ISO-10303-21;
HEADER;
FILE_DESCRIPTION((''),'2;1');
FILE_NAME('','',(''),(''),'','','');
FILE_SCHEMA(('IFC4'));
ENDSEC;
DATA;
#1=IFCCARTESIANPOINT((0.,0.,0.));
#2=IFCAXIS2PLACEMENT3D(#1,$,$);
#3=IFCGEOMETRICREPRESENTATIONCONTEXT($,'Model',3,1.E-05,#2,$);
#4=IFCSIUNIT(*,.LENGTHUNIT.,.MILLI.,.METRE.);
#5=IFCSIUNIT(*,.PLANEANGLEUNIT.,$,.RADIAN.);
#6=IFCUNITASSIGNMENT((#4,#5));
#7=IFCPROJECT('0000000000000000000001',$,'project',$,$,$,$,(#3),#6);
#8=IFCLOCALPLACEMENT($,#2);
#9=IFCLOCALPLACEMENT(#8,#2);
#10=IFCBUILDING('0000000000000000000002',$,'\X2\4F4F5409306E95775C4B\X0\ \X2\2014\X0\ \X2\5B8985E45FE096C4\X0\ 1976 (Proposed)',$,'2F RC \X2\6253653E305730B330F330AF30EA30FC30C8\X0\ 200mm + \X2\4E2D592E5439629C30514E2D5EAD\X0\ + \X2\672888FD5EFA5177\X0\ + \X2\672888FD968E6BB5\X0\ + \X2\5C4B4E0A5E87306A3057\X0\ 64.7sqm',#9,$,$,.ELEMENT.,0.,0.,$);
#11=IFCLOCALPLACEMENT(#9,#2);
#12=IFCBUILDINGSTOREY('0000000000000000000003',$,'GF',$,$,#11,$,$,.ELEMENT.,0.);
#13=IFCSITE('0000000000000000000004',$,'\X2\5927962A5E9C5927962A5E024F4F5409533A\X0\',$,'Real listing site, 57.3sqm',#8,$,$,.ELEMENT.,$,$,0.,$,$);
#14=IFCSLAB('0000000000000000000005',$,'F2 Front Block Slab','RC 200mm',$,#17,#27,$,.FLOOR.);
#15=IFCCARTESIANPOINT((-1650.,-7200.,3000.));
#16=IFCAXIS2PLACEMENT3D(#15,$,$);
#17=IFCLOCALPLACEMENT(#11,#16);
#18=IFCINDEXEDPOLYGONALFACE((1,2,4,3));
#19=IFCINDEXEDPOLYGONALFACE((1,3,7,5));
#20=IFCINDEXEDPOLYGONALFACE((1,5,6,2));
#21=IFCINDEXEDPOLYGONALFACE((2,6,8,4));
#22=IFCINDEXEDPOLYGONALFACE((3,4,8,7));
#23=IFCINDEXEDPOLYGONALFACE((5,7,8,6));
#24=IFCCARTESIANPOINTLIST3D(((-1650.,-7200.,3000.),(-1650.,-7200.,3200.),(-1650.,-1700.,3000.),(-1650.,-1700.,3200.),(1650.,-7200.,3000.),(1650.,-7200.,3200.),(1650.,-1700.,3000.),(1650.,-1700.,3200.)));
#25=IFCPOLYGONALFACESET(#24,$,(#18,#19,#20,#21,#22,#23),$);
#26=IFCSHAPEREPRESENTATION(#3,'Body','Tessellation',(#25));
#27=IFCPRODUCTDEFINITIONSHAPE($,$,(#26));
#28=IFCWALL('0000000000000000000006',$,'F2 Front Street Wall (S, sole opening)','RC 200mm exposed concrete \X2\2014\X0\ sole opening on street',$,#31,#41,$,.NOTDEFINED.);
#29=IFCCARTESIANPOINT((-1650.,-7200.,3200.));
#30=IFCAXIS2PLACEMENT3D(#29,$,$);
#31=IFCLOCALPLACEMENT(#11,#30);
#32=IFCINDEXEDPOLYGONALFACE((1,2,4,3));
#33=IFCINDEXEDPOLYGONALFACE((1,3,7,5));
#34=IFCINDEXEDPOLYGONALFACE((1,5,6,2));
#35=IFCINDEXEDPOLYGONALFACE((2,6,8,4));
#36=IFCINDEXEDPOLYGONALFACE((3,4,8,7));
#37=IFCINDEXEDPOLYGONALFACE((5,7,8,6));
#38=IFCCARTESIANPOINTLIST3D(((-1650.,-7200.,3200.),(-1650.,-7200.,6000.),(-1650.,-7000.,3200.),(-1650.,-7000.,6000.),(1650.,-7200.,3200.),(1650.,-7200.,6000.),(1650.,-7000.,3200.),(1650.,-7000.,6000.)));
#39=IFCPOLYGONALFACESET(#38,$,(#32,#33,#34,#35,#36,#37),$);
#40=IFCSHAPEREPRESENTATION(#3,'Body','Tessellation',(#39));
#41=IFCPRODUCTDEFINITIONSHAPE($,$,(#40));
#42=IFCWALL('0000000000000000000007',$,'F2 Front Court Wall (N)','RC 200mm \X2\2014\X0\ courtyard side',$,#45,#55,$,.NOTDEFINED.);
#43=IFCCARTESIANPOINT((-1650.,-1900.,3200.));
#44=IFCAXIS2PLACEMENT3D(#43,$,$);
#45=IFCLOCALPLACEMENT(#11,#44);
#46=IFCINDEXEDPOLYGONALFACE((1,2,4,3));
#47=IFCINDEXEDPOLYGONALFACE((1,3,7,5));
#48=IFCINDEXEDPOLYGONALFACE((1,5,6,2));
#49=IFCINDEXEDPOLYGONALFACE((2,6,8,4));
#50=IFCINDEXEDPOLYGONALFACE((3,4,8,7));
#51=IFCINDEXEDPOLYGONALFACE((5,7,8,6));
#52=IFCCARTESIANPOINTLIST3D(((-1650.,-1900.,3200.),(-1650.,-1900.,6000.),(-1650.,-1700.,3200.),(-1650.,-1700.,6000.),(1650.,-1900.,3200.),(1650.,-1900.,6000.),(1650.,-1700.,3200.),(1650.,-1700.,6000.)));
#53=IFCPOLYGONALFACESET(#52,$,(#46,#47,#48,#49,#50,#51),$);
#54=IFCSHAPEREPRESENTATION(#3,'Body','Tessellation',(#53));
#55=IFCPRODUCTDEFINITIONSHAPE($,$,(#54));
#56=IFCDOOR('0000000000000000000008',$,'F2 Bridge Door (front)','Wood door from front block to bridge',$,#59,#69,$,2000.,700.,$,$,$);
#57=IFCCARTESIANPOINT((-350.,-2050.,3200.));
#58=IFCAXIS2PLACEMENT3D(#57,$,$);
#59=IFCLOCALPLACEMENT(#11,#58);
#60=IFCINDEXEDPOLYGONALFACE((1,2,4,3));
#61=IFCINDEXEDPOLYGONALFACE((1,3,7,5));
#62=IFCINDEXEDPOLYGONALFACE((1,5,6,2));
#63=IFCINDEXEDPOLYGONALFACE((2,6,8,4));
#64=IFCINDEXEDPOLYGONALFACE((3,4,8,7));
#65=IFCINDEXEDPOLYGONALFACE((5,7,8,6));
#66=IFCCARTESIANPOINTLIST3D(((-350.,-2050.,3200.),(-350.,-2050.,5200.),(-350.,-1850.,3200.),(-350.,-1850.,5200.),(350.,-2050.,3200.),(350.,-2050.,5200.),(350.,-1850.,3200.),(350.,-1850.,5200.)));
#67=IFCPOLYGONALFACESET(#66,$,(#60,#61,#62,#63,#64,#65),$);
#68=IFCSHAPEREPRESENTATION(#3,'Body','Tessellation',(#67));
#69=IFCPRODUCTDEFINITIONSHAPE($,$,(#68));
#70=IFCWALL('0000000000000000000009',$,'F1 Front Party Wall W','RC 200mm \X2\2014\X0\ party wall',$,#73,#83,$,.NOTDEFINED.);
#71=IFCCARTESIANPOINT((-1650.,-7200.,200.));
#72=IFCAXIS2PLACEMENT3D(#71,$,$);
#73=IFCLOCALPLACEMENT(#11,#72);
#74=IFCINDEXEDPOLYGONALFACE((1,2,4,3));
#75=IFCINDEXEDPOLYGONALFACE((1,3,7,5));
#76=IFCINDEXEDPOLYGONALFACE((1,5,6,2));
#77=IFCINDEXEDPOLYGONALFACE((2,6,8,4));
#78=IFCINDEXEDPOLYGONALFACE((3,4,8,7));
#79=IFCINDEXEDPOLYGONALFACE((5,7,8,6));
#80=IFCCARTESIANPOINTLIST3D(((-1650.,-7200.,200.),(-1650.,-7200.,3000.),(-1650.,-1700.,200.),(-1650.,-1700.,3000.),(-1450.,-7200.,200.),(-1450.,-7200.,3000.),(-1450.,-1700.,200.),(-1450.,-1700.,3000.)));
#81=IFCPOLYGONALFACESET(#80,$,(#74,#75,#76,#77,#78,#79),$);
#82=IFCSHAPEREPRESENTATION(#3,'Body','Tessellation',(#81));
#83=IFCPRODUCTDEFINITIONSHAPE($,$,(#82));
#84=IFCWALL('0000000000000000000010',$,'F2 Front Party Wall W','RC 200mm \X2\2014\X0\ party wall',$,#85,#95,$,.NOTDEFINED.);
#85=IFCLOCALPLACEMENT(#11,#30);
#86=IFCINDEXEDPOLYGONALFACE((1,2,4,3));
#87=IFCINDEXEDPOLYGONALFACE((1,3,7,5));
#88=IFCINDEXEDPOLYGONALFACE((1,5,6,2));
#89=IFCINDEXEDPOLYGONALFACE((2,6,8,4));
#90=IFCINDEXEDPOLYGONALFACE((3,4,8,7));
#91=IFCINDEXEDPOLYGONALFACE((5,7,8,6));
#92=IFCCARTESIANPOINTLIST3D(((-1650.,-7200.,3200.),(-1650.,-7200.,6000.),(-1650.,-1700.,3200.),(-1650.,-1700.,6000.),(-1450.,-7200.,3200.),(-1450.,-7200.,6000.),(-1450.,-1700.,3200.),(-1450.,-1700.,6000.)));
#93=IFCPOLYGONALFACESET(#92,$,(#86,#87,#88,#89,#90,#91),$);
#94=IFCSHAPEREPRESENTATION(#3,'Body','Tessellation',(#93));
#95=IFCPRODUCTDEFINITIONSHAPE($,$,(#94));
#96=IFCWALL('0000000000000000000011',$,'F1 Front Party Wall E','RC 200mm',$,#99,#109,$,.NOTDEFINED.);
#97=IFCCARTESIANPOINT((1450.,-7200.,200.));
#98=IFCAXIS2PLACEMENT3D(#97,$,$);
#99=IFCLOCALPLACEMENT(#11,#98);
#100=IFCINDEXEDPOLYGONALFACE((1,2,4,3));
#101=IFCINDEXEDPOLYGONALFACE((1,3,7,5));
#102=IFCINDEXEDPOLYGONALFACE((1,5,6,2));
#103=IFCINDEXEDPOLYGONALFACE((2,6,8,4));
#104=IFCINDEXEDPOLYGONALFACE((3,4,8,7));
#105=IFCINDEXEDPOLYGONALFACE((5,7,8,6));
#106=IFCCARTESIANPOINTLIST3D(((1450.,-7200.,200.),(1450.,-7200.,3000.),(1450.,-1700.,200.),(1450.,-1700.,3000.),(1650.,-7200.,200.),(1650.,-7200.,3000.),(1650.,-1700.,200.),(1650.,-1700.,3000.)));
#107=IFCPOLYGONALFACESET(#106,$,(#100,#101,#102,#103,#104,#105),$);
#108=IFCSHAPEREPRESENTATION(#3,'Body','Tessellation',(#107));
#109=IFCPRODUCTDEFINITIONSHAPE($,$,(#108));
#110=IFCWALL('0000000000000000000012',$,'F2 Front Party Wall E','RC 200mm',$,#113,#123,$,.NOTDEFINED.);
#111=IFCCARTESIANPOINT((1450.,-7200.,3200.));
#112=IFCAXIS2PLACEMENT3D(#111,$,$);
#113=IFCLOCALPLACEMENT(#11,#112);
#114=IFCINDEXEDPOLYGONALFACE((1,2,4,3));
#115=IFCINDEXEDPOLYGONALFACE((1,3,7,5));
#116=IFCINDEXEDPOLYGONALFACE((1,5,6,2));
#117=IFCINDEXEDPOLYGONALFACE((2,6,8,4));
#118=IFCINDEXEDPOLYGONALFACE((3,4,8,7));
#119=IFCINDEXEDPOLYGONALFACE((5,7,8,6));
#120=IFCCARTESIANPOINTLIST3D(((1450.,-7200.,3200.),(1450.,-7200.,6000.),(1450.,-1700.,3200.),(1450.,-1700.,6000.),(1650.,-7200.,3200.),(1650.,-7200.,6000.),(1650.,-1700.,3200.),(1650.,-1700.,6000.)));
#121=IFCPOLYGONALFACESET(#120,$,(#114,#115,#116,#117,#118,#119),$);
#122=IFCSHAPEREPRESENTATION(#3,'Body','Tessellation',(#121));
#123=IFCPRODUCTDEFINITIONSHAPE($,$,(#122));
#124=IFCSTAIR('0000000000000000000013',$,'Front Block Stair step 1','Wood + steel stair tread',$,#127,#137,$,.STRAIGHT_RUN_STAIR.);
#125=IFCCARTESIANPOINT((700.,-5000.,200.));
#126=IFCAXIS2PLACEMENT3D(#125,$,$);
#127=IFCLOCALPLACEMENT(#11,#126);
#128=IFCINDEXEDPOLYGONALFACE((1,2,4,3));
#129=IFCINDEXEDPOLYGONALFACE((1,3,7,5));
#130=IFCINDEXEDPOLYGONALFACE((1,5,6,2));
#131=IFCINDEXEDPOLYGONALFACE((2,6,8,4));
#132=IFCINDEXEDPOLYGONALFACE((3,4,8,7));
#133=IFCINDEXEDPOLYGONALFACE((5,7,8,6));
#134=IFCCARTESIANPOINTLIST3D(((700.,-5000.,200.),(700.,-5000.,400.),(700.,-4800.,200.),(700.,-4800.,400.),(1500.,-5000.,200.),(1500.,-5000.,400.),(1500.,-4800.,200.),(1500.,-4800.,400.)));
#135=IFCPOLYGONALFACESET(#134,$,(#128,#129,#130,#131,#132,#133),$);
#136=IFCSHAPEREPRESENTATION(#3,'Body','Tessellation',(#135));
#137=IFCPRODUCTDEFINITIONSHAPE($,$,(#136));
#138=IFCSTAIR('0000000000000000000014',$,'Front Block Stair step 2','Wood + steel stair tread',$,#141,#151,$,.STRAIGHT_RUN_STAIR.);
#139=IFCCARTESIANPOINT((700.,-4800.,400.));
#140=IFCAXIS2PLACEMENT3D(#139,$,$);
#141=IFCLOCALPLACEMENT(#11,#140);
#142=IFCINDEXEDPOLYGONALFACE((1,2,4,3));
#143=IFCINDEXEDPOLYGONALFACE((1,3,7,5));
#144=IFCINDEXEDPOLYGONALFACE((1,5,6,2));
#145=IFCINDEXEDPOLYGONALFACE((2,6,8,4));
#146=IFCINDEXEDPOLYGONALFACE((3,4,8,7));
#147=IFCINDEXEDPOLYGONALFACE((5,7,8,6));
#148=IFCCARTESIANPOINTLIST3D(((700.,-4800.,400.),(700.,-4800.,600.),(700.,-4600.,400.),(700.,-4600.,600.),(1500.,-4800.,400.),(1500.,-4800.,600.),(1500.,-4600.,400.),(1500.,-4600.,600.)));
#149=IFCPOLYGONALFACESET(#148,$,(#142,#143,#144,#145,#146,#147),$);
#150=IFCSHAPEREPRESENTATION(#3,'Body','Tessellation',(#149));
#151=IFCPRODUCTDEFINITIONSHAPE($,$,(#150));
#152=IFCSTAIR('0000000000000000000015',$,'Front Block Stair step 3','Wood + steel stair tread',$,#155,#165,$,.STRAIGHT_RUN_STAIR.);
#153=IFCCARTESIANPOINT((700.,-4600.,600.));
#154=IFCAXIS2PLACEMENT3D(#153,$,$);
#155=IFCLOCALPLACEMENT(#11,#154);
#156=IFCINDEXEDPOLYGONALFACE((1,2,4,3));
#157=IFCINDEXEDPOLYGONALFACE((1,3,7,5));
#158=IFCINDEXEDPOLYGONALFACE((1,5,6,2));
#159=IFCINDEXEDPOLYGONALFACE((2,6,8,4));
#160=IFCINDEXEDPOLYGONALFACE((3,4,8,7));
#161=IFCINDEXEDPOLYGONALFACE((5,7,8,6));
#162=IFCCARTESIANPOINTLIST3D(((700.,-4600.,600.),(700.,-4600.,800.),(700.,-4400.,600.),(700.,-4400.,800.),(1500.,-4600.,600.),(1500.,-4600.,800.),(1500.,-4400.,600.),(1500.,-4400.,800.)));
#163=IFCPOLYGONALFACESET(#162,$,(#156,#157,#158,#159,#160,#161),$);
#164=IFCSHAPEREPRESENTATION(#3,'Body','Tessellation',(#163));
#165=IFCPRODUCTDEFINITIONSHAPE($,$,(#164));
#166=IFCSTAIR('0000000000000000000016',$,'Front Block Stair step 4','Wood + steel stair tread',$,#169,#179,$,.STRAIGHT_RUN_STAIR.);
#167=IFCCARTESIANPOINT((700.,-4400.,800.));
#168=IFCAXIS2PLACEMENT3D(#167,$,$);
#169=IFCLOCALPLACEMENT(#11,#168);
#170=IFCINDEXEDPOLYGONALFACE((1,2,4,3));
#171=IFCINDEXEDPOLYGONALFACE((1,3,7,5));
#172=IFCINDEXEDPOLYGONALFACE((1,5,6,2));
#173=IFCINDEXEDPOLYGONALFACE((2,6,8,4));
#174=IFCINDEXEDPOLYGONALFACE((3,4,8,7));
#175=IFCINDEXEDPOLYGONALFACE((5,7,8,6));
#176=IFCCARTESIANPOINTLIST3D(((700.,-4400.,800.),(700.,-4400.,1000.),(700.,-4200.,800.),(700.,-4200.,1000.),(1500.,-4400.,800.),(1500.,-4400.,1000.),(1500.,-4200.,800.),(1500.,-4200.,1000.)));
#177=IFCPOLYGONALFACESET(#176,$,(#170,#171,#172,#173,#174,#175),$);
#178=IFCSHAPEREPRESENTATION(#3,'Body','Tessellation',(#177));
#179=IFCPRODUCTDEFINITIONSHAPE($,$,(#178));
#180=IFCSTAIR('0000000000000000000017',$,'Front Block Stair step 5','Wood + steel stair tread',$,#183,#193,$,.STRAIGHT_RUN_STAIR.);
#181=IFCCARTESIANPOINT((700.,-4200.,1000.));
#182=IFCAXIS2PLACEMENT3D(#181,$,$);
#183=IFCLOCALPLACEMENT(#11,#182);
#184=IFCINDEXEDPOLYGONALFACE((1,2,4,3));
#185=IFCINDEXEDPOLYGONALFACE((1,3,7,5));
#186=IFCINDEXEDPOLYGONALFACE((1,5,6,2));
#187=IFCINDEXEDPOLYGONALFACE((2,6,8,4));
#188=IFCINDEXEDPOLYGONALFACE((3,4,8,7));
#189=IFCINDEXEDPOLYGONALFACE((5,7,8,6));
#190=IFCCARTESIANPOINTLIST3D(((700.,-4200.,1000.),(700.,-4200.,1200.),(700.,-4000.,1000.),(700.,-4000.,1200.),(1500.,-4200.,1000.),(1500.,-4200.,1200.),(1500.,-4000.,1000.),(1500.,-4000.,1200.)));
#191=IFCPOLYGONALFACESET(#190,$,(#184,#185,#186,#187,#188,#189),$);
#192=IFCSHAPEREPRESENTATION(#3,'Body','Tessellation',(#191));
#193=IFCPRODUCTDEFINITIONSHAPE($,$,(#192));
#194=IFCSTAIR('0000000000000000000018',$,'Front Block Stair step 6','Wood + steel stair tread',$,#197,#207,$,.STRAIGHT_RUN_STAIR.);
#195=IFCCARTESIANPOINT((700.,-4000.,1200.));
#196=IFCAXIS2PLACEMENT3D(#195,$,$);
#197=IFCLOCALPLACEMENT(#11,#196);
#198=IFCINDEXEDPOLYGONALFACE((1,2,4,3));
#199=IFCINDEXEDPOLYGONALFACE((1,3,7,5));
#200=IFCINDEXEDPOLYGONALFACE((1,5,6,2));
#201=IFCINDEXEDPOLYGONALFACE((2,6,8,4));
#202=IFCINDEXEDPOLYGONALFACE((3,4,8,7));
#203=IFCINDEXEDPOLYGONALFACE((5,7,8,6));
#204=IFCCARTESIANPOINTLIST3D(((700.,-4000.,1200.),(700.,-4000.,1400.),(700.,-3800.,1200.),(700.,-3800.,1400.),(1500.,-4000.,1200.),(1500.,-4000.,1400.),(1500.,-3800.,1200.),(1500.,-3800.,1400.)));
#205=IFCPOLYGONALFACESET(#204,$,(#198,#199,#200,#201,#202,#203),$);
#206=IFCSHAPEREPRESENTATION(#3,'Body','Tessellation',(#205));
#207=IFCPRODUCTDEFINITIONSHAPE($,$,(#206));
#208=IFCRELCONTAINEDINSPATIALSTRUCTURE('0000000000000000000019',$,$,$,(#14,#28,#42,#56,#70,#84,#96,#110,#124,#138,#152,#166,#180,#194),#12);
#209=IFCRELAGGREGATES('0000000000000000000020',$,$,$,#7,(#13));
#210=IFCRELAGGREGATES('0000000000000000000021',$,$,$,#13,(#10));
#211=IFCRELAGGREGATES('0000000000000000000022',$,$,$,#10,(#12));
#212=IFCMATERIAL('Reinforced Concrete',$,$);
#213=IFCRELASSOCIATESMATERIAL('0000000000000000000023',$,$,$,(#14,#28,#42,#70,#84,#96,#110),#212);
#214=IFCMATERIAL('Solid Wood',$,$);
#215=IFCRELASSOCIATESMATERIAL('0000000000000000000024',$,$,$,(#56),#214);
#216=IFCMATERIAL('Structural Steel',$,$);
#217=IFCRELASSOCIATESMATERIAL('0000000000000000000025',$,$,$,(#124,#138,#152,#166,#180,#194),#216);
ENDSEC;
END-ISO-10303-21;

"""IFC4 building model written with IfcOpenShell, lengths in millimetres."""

from ifc_helpers import new_model, si_unit, frame, frame_2d, origin, place, context, project, spatial, rectangle, extrude, material, element, fill, save


model = new_model("IFC4")

# Units and contexts
model_context = context("Model", 3, precision=1e-05, world=origin())
ifc_project = project(units=[si_unit("LENGTHUNIT", "METRE", prefix="MILLI"), si_unit("PLANEANGLEUNIT", "RADIAN")], contexts=[model_context])

# Site, building, storey
site_placement = place(None, origin())
site = spatial("IfcSite", under=ifc_project, at=site_placement, Name="大阪府大阪市住吉区", ObjectType="Real listing site, 57.3sqm", CompositionType="ELEMENT", RefElevation=0.0)
building_placement = place(site_placement, origin())
building = spatial("IfcBuilding", under=site, at=building_placement, Name="住吉の長屋 — 安藤忠雄 1976 (Proposed)", ObjectType="2F RC 打放しコンクリート 200mm + 中央吹抜け中庭 + 木製建具 + 木製階段 + 屋上庇なし 64.7sqm", CompositionType="ELEMENT", ElevationOfRefHeight=0.0, ElevationOfTerrain=0.0)
storey_placement = place(building_placement, origin())
storey = spatial("IfcBuildingStorey", under=building, at=storey_placement, Name="GF", CompositionType="ELEMENT", Elevation=0.0)

# Slab
ifc_material_1 = material(Name="Reinforced Concrete")
slab_1_placement = place(storey_placement, frame((-1650.0, -7200.0, 3000.0)))
element("IfcSlab", 1, at=slab_1_placement, inside=storey, material=ifc_material_1, Name="F2 Front Block Slab", Description="RC 200mm", PredefinedType="FLOOR", context=model_context, shape_type="SweptSolid", body=[
    extrude(rectangle(XDim=3300.0, YDim=5500.0, at=frame_2d((1650.0, 2750.0))), frame((-1650.0, -7200.0, 3000.0)), (0.0, 0.0, 1.0), 200.0),
])

# Shared definitions
ifc_material_2 = material(Name="Solid Wood")

# Wall
wall_1_placement = place(storey_placement, frame((-1650.0, -7200.0, 3200.0)))
element("IfcWall", 2, at=wall_1_placement, inside=storey, material=ifc_material_1, Name="F2 Front Street Wall (S, sole opening)", Description="RC 200mm exposed concrete — sole opening on street", PredefinedType="NOTDEFINED", context=model_context, shape_type="SweptSolid", body=[
    extrude(rectangle(XDim=3300.0, YDim=200.0, at=frame_2d((1650.0, 100.0))), frame((-1650.0, -7200.0, 3200.0)), (0.0, 0.0, 1.0), 2800.0),
])

# Wall, opening, door
wall_2_placement = place(storey_placement, frame((-1650.0, -1900.0, 3200.0)))
wall_2 = element("IfcWall", 3, at=wall_2_placement, inside=storey, material=ifc_material_1, Name="F2 Front Court Wall (N)", Description="RC 200mm — courtyard side", PredefinedType="NOTDEFINED", context=model_context, shape_type="SweptSolid", body=[
    extrude(rectangle(XDim=3300.0, YDim=200.0, at=frame_2d((1650.0, 100.0))), frame((-1650.0, -1900.0, 3200.0)), (0.0, 0.0, 1.0), 2800.0),
])
opening_1_placement = place(storey_placement, frame((-350.0, -2050.0, 3200.0)))
opening_1 = element("IfcOpeningElement", 4, at=opening_1_placement, cuts=wall_2, PredefinedType="NOTDEFINED", context=model_context, shape_type="SweptSolid", body=[
    extrude(rectangle(XDim=700.0, YDim=200.0, at=frame_2d((350.0, 100.0))), frame((-350.0, -2050.0, 3200.0)), (0.0, 0.0, 1.0), 2000.0),
])
door_1_placement = place(storey_placement, frame((-350.0, -2050.0, 3200.0)))
door_1 = element("IfcDoor", 5, at=door_1_placement, inside=storey, material=ifc_material_2, Name="F2 Bridge Door (front)", Description="Wood door from front block to bridge", OverallHeight=2000.0, OverallWidth=700.0, context=model_context, shape_type="SweptSolid", body=[
    extrude(rectangle(XDim=700.0, YDim=200.0, at=frame_2d((350.0, 100.0))), frame((-350.0, -2050.0, 3200.0)), (0.0, 0.0, 1.0), 2000.0),
])
fill(opening_1, door_1)

# Walls
wall_3_placement = place(storey_placement, frame((-1650.0, -7200.0, 200.0)))
element("IfcWall", 6, at=wall_3_placement, inside=storey, material=ifc_material_1, Name="F1 Front Party Wall W", Description="RC 200mm — party wall", PredefinedType="NOTDEFINED", context=model_context, shape_type="SweptSolid", body=[
    extrude(rectangle(XDim=200.0, YDim=5500.0, at=frame_2d((100.0, 2750.0))), frame((-1650.0, -7200.0, 200.0)), (0.0, 0.0, 1.0), 2800.0),
])
wall_4_placement = place(storey_placement, frame((-1650.0, -7200.0, 3200.0)))
element("IfcWall", 7, at=wall_4_placement, inside=storey, material=ifc_material_1, Name="F2 Front Party Wall W", Description="RC 200mm — party wall", PredefinedType="NOTDEFINED", context=model_context, shape_type="SweptSolid", body=[
    extrude(rectangle(XDim=200.0, YDim=5500.0, at=frame_2d((100.0, 2750.0))), frame((-1650.0, -7200.0, 3200.0)), (0.0, 0.0, 1.0), 2800.0),
])
wall_5_placement = place(storey_placement, frame((1450.0, -7200.0, 200.0)))
element("IfcWall", 8, at=wall_5_placement, inside=storey, material=ifc_material_1, Name="F1 Front Party Wall E", Description="RC 200mm", PredefinedType="NOTDEFINED", context=model_context, shape_type="SweptSolid", body=[
    extrude(rectangle(XDim=200.0, YDim=5500.0, at=frame_2d((100.0, 2750.0))), frame((1450.0, -7200.0, 200.0)), (0.0, 0.0, 1.0), 2800.0),
])
wall_6_placement = place(storey_placement, frame((1450.0, -7200.0, 3200.0)))
element("IfcWall", 9, at=wall_6_placement, inside=storey, material=ifc_material_1, Name="F2 Front Party Wall E", Description="RC 200mm", PredefinedType="NOTDEFINED", context=model_context, shape_type="SweptSolid", body=[
    extrude(rectangle(XDim=200.0, YDim=5500.0, at=frame_2d((100.0, 2750.0))), frame((1450.0, -7200.0, 3200.0)), (0.0, 0.0, 1.0), 2800.0),
])

# Stairs
ifc_material_3 = material(Name="Structural Steel")
stair_1_placement = place(storey_placement, frame((700.0, -5000.0, 200.0)))
element("IfcStair", 10, at=stair_1_placement, inside=storey, material=ifc_material_3, Name="Front Block Stair step 1", Description="Wood + steel stair tread", PredefinedType="STRAIGHT_RUN_STAIR", context=model_context, shape_type="SweptSolid", body=[
    extrude(rectangle(XDim=800.0, YDim=200.0, at=frame_2d((400.0, 100.0))), frame((700.0, -5000.0, 200.0)), (0.0, 0.0, 1.0), 200.0),
])
stair_2_placement = place(storey_placement, frame((700.0, -4800.0, 400.0)))
element("IfcStair", 11, at=stair_2_placement, inside=storey, material=ifc_material_3, Name="Front Block Stair step 2", Description="Wood + steel stair tread", PredefinedType="STRAIGHT_RUN_STAIR", context=model_context, shape_type="SweptSolid", body=[
    extrude(rectangle(XDim=800.0, YDim=200.0, at=frame_2d((400.0, 100.0))), frame((700.0, -4800.0, 400.0)), (0.0, 0.0, 1.0), 200.0),
])
stair_3_placement = place(storey_placement, frame((700.0, -4600.0, 600.0)))
element("IfcStair", 12, at=stair_3_placement, inside=storey, material=ifc_material_3, Name="Front Block Stair step 3", Description="Wood + steel stair tread", PredefinedType="STRAIGHT_RUN_STAIR", context=model_context, shape_type="SweptSolid", body=[
    extrude(rectangle(XDim=800.0, YDim=200.0, at=frame_2d((400.0, 100.0))), frame((700.0, -4600.0, 600.0)), (0.0, 0.0, 1.0), 200.0),
])
stair_4_placement = place(storey_placement, frame((700.0, -4400.0, 800.0)))
element("IfcStair", 13, at=stair_4_placement, inside=storey, material=ifc_material_3, Name="Front Block Stair step 4", Description="Wood + steel stair tread", PredefinedType="STRAIGHT_RUN_STAIR", context=model_context, shape_type="SweptSolid", body=[
    extrude(rectangle(XDim=800.0, YDim=200.0, at=frame_2d((400.0, 100.0))), frame((700.0, -4400.0, 800.0)), (0.0, 0.0, 1.0), 200.0),
])
stair_5_placement = place(storey_placement, frame((700.0, -4200.0, 1000.0)))
element("IfcStair", 14, at=stair_5_placement, inside=storey, material=ifc_material_3, Name="Front Block Stair step 5", Description="Wood + steel stair tread", PredefinedType="STRAIGHT_RUN_STAIR", context=model_context, shape_type="SweptSolid", body=[
    extrude(rectangle(XDim=800.0, YDim=200.0, at=frame_2d((400.0, 100.0))), frame((700.0, -4200.0, 1000.0)), (0.0, 0.0, 1.0), 200.0),
])
stair_6_placement = place(storey_placement, frame((700.0, -4000.0, 1200.0)))
element("IfcStair", 15, at=stair_6_placement, inside=storey, material=ifc_material_3, Name="Front Block Stair step 6", Description="Wood + steel stair tread", PredefinedType="STRAIGHT_RUN_STAIR", context=model_context, shape_type="SweptSolid", body=[
    extrude(rectangle(XDim=800.0, YDim=200.0, at=frame_2d((400.0, 100.0))), frame((700.0, -4000.0, 1200.0)), (0.0, 0.0, 1.0), 200.0),
])

save(model, "model.ifc")
